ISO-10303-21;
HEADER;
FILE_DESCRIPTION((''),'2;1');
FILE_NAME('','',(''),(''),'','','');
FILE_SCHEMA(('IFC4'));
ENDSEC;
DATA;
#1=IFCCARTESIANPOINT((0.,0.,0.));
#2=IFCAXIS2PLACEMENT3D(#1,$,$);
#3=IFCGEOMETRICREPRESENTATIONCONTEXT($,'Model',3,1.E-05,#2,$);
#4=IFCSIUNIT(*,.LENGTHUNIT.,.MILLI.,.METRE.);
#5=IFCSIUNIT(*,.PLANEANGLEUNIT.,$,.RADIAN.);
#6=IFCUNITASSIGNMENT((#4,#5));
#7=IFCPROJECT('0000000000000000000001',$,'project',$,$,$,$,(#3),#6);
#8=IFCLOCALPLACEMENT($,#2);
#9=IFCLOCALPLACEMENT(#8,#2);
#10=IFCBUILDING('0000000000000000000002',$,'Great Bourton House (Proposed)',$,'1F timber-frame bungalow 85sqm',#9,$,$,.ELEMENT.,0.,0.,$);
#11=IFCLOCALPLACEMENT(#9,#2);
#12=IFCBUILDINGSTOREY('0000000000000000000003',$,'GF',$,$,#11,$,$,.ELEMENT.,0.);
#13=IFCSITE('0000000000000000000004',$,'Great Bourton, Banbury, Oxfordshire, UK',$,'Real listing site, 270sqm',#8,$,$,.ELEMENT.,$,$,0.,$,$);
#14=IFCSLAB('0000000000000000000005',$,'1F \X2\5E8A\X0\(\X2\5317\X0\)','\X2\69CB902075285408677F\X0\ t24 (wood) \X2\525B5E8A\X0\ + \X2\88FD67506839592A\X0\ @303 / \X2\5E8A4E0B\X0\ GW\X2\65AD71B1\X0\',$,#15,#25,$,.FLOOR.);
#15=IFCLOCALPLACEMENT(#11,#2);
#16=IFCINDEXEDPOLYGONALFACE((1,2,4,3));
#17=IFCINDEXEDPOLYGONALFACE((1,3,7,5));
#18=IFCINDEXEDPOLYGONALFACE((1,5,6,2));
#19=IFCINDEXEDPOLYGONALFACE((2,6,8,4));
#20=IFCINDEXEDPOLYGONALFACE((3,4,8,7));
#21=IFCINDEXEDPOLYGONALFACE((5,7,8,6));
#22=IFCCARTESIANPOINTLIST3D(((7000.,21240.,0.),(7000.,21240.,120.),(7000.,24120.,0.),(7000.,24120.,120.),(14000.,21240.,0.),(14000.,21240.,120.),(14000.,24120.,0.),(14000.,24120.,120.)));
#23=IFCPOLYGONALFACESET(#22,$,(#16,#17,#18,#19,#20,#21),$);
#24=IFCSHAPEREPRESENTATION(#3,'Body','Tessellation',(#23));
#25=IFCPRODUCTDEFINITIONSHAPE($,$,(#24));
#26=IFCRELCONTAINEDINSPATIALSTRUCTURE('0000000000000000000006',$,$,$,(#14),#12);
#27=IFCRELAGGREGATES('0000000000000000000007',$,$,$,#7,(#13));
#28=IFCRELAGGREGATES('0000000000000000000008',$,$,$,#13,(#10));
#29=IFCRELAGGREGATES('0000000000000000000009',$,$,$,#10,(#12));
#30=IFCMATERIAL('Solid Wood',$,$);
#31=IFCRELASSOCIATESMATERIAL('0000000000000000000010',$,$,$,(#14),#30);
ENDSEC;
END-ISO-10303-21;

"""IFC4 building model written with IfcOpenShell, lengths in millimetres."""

from ifc_helpers import new_model, si_unit, frame, frame_2d, origin, place, context, project, spatial, rectangle, extrude, material, element, save


model = new_model("IFC4")

# Units and contexts
model_context = context("Model", 3, precision=1e-05, world=origin())
ifc_project = project(units=[si_unit("LENGTHUNIT", "METRE", prefix="MILLI"), si_unit("PLANEANGLEUNIT", "RADIAN")], contexts=[model_context])

# Site, building, storey
site_placement = place(None, origin())
site = spatial("IfcSite", under=ifc_project, at=site_placement, Name="Great Bourton, Banbury, Oxfordshire, UK", ObjectType="Real listing site, 270sqm", CompositionType="ELEMENT", RefElevation=0.0)
building_placement = place(site_placement, origin())
building = spatial("IfcBuilding", under=site, at=building_placement, Name="Great Bourton House (Proposed)", ObjectType="1F timber-frame bungalow 85sqm", CompositionType="ELEMENT", ElevationOfRefHeight=0.0, ElevationOfTerrain=0.0)
storey_placement = place(building_placement, origin())
storey = spatial("IfcBuildingStorey", under=building, at=storey_placement, Name="GF", CompositionType="ELEMENT", Elevation=0.0)

# Slab
ifc_material_1 = material(Name="Solid Wood")
slab_1_placement = place(storey_placement, frame((3500.0, 10620.0, 0.0)))
element("IfcSlab", 1, at=slab_1_placement, inside=storey, material=ifc_material_1, Name="1F 床(北)", Description="構造用合板 t24 (wood) 剛床 + 製材根太 @303 / 床下 GW断熱", PredefinedType="FLOOR", context=model_context, shape_type="SweptSolid", body=[
    extrude(rectangle(XDim=7000.0, YDim=2880.0, at=frame_2d((3500.0, 1440.0))), frame((3500.0, 10620.0, 0.0)), (0.0, 0.0, 1.0), 120.0),
])

save(model, "model.ifc")
